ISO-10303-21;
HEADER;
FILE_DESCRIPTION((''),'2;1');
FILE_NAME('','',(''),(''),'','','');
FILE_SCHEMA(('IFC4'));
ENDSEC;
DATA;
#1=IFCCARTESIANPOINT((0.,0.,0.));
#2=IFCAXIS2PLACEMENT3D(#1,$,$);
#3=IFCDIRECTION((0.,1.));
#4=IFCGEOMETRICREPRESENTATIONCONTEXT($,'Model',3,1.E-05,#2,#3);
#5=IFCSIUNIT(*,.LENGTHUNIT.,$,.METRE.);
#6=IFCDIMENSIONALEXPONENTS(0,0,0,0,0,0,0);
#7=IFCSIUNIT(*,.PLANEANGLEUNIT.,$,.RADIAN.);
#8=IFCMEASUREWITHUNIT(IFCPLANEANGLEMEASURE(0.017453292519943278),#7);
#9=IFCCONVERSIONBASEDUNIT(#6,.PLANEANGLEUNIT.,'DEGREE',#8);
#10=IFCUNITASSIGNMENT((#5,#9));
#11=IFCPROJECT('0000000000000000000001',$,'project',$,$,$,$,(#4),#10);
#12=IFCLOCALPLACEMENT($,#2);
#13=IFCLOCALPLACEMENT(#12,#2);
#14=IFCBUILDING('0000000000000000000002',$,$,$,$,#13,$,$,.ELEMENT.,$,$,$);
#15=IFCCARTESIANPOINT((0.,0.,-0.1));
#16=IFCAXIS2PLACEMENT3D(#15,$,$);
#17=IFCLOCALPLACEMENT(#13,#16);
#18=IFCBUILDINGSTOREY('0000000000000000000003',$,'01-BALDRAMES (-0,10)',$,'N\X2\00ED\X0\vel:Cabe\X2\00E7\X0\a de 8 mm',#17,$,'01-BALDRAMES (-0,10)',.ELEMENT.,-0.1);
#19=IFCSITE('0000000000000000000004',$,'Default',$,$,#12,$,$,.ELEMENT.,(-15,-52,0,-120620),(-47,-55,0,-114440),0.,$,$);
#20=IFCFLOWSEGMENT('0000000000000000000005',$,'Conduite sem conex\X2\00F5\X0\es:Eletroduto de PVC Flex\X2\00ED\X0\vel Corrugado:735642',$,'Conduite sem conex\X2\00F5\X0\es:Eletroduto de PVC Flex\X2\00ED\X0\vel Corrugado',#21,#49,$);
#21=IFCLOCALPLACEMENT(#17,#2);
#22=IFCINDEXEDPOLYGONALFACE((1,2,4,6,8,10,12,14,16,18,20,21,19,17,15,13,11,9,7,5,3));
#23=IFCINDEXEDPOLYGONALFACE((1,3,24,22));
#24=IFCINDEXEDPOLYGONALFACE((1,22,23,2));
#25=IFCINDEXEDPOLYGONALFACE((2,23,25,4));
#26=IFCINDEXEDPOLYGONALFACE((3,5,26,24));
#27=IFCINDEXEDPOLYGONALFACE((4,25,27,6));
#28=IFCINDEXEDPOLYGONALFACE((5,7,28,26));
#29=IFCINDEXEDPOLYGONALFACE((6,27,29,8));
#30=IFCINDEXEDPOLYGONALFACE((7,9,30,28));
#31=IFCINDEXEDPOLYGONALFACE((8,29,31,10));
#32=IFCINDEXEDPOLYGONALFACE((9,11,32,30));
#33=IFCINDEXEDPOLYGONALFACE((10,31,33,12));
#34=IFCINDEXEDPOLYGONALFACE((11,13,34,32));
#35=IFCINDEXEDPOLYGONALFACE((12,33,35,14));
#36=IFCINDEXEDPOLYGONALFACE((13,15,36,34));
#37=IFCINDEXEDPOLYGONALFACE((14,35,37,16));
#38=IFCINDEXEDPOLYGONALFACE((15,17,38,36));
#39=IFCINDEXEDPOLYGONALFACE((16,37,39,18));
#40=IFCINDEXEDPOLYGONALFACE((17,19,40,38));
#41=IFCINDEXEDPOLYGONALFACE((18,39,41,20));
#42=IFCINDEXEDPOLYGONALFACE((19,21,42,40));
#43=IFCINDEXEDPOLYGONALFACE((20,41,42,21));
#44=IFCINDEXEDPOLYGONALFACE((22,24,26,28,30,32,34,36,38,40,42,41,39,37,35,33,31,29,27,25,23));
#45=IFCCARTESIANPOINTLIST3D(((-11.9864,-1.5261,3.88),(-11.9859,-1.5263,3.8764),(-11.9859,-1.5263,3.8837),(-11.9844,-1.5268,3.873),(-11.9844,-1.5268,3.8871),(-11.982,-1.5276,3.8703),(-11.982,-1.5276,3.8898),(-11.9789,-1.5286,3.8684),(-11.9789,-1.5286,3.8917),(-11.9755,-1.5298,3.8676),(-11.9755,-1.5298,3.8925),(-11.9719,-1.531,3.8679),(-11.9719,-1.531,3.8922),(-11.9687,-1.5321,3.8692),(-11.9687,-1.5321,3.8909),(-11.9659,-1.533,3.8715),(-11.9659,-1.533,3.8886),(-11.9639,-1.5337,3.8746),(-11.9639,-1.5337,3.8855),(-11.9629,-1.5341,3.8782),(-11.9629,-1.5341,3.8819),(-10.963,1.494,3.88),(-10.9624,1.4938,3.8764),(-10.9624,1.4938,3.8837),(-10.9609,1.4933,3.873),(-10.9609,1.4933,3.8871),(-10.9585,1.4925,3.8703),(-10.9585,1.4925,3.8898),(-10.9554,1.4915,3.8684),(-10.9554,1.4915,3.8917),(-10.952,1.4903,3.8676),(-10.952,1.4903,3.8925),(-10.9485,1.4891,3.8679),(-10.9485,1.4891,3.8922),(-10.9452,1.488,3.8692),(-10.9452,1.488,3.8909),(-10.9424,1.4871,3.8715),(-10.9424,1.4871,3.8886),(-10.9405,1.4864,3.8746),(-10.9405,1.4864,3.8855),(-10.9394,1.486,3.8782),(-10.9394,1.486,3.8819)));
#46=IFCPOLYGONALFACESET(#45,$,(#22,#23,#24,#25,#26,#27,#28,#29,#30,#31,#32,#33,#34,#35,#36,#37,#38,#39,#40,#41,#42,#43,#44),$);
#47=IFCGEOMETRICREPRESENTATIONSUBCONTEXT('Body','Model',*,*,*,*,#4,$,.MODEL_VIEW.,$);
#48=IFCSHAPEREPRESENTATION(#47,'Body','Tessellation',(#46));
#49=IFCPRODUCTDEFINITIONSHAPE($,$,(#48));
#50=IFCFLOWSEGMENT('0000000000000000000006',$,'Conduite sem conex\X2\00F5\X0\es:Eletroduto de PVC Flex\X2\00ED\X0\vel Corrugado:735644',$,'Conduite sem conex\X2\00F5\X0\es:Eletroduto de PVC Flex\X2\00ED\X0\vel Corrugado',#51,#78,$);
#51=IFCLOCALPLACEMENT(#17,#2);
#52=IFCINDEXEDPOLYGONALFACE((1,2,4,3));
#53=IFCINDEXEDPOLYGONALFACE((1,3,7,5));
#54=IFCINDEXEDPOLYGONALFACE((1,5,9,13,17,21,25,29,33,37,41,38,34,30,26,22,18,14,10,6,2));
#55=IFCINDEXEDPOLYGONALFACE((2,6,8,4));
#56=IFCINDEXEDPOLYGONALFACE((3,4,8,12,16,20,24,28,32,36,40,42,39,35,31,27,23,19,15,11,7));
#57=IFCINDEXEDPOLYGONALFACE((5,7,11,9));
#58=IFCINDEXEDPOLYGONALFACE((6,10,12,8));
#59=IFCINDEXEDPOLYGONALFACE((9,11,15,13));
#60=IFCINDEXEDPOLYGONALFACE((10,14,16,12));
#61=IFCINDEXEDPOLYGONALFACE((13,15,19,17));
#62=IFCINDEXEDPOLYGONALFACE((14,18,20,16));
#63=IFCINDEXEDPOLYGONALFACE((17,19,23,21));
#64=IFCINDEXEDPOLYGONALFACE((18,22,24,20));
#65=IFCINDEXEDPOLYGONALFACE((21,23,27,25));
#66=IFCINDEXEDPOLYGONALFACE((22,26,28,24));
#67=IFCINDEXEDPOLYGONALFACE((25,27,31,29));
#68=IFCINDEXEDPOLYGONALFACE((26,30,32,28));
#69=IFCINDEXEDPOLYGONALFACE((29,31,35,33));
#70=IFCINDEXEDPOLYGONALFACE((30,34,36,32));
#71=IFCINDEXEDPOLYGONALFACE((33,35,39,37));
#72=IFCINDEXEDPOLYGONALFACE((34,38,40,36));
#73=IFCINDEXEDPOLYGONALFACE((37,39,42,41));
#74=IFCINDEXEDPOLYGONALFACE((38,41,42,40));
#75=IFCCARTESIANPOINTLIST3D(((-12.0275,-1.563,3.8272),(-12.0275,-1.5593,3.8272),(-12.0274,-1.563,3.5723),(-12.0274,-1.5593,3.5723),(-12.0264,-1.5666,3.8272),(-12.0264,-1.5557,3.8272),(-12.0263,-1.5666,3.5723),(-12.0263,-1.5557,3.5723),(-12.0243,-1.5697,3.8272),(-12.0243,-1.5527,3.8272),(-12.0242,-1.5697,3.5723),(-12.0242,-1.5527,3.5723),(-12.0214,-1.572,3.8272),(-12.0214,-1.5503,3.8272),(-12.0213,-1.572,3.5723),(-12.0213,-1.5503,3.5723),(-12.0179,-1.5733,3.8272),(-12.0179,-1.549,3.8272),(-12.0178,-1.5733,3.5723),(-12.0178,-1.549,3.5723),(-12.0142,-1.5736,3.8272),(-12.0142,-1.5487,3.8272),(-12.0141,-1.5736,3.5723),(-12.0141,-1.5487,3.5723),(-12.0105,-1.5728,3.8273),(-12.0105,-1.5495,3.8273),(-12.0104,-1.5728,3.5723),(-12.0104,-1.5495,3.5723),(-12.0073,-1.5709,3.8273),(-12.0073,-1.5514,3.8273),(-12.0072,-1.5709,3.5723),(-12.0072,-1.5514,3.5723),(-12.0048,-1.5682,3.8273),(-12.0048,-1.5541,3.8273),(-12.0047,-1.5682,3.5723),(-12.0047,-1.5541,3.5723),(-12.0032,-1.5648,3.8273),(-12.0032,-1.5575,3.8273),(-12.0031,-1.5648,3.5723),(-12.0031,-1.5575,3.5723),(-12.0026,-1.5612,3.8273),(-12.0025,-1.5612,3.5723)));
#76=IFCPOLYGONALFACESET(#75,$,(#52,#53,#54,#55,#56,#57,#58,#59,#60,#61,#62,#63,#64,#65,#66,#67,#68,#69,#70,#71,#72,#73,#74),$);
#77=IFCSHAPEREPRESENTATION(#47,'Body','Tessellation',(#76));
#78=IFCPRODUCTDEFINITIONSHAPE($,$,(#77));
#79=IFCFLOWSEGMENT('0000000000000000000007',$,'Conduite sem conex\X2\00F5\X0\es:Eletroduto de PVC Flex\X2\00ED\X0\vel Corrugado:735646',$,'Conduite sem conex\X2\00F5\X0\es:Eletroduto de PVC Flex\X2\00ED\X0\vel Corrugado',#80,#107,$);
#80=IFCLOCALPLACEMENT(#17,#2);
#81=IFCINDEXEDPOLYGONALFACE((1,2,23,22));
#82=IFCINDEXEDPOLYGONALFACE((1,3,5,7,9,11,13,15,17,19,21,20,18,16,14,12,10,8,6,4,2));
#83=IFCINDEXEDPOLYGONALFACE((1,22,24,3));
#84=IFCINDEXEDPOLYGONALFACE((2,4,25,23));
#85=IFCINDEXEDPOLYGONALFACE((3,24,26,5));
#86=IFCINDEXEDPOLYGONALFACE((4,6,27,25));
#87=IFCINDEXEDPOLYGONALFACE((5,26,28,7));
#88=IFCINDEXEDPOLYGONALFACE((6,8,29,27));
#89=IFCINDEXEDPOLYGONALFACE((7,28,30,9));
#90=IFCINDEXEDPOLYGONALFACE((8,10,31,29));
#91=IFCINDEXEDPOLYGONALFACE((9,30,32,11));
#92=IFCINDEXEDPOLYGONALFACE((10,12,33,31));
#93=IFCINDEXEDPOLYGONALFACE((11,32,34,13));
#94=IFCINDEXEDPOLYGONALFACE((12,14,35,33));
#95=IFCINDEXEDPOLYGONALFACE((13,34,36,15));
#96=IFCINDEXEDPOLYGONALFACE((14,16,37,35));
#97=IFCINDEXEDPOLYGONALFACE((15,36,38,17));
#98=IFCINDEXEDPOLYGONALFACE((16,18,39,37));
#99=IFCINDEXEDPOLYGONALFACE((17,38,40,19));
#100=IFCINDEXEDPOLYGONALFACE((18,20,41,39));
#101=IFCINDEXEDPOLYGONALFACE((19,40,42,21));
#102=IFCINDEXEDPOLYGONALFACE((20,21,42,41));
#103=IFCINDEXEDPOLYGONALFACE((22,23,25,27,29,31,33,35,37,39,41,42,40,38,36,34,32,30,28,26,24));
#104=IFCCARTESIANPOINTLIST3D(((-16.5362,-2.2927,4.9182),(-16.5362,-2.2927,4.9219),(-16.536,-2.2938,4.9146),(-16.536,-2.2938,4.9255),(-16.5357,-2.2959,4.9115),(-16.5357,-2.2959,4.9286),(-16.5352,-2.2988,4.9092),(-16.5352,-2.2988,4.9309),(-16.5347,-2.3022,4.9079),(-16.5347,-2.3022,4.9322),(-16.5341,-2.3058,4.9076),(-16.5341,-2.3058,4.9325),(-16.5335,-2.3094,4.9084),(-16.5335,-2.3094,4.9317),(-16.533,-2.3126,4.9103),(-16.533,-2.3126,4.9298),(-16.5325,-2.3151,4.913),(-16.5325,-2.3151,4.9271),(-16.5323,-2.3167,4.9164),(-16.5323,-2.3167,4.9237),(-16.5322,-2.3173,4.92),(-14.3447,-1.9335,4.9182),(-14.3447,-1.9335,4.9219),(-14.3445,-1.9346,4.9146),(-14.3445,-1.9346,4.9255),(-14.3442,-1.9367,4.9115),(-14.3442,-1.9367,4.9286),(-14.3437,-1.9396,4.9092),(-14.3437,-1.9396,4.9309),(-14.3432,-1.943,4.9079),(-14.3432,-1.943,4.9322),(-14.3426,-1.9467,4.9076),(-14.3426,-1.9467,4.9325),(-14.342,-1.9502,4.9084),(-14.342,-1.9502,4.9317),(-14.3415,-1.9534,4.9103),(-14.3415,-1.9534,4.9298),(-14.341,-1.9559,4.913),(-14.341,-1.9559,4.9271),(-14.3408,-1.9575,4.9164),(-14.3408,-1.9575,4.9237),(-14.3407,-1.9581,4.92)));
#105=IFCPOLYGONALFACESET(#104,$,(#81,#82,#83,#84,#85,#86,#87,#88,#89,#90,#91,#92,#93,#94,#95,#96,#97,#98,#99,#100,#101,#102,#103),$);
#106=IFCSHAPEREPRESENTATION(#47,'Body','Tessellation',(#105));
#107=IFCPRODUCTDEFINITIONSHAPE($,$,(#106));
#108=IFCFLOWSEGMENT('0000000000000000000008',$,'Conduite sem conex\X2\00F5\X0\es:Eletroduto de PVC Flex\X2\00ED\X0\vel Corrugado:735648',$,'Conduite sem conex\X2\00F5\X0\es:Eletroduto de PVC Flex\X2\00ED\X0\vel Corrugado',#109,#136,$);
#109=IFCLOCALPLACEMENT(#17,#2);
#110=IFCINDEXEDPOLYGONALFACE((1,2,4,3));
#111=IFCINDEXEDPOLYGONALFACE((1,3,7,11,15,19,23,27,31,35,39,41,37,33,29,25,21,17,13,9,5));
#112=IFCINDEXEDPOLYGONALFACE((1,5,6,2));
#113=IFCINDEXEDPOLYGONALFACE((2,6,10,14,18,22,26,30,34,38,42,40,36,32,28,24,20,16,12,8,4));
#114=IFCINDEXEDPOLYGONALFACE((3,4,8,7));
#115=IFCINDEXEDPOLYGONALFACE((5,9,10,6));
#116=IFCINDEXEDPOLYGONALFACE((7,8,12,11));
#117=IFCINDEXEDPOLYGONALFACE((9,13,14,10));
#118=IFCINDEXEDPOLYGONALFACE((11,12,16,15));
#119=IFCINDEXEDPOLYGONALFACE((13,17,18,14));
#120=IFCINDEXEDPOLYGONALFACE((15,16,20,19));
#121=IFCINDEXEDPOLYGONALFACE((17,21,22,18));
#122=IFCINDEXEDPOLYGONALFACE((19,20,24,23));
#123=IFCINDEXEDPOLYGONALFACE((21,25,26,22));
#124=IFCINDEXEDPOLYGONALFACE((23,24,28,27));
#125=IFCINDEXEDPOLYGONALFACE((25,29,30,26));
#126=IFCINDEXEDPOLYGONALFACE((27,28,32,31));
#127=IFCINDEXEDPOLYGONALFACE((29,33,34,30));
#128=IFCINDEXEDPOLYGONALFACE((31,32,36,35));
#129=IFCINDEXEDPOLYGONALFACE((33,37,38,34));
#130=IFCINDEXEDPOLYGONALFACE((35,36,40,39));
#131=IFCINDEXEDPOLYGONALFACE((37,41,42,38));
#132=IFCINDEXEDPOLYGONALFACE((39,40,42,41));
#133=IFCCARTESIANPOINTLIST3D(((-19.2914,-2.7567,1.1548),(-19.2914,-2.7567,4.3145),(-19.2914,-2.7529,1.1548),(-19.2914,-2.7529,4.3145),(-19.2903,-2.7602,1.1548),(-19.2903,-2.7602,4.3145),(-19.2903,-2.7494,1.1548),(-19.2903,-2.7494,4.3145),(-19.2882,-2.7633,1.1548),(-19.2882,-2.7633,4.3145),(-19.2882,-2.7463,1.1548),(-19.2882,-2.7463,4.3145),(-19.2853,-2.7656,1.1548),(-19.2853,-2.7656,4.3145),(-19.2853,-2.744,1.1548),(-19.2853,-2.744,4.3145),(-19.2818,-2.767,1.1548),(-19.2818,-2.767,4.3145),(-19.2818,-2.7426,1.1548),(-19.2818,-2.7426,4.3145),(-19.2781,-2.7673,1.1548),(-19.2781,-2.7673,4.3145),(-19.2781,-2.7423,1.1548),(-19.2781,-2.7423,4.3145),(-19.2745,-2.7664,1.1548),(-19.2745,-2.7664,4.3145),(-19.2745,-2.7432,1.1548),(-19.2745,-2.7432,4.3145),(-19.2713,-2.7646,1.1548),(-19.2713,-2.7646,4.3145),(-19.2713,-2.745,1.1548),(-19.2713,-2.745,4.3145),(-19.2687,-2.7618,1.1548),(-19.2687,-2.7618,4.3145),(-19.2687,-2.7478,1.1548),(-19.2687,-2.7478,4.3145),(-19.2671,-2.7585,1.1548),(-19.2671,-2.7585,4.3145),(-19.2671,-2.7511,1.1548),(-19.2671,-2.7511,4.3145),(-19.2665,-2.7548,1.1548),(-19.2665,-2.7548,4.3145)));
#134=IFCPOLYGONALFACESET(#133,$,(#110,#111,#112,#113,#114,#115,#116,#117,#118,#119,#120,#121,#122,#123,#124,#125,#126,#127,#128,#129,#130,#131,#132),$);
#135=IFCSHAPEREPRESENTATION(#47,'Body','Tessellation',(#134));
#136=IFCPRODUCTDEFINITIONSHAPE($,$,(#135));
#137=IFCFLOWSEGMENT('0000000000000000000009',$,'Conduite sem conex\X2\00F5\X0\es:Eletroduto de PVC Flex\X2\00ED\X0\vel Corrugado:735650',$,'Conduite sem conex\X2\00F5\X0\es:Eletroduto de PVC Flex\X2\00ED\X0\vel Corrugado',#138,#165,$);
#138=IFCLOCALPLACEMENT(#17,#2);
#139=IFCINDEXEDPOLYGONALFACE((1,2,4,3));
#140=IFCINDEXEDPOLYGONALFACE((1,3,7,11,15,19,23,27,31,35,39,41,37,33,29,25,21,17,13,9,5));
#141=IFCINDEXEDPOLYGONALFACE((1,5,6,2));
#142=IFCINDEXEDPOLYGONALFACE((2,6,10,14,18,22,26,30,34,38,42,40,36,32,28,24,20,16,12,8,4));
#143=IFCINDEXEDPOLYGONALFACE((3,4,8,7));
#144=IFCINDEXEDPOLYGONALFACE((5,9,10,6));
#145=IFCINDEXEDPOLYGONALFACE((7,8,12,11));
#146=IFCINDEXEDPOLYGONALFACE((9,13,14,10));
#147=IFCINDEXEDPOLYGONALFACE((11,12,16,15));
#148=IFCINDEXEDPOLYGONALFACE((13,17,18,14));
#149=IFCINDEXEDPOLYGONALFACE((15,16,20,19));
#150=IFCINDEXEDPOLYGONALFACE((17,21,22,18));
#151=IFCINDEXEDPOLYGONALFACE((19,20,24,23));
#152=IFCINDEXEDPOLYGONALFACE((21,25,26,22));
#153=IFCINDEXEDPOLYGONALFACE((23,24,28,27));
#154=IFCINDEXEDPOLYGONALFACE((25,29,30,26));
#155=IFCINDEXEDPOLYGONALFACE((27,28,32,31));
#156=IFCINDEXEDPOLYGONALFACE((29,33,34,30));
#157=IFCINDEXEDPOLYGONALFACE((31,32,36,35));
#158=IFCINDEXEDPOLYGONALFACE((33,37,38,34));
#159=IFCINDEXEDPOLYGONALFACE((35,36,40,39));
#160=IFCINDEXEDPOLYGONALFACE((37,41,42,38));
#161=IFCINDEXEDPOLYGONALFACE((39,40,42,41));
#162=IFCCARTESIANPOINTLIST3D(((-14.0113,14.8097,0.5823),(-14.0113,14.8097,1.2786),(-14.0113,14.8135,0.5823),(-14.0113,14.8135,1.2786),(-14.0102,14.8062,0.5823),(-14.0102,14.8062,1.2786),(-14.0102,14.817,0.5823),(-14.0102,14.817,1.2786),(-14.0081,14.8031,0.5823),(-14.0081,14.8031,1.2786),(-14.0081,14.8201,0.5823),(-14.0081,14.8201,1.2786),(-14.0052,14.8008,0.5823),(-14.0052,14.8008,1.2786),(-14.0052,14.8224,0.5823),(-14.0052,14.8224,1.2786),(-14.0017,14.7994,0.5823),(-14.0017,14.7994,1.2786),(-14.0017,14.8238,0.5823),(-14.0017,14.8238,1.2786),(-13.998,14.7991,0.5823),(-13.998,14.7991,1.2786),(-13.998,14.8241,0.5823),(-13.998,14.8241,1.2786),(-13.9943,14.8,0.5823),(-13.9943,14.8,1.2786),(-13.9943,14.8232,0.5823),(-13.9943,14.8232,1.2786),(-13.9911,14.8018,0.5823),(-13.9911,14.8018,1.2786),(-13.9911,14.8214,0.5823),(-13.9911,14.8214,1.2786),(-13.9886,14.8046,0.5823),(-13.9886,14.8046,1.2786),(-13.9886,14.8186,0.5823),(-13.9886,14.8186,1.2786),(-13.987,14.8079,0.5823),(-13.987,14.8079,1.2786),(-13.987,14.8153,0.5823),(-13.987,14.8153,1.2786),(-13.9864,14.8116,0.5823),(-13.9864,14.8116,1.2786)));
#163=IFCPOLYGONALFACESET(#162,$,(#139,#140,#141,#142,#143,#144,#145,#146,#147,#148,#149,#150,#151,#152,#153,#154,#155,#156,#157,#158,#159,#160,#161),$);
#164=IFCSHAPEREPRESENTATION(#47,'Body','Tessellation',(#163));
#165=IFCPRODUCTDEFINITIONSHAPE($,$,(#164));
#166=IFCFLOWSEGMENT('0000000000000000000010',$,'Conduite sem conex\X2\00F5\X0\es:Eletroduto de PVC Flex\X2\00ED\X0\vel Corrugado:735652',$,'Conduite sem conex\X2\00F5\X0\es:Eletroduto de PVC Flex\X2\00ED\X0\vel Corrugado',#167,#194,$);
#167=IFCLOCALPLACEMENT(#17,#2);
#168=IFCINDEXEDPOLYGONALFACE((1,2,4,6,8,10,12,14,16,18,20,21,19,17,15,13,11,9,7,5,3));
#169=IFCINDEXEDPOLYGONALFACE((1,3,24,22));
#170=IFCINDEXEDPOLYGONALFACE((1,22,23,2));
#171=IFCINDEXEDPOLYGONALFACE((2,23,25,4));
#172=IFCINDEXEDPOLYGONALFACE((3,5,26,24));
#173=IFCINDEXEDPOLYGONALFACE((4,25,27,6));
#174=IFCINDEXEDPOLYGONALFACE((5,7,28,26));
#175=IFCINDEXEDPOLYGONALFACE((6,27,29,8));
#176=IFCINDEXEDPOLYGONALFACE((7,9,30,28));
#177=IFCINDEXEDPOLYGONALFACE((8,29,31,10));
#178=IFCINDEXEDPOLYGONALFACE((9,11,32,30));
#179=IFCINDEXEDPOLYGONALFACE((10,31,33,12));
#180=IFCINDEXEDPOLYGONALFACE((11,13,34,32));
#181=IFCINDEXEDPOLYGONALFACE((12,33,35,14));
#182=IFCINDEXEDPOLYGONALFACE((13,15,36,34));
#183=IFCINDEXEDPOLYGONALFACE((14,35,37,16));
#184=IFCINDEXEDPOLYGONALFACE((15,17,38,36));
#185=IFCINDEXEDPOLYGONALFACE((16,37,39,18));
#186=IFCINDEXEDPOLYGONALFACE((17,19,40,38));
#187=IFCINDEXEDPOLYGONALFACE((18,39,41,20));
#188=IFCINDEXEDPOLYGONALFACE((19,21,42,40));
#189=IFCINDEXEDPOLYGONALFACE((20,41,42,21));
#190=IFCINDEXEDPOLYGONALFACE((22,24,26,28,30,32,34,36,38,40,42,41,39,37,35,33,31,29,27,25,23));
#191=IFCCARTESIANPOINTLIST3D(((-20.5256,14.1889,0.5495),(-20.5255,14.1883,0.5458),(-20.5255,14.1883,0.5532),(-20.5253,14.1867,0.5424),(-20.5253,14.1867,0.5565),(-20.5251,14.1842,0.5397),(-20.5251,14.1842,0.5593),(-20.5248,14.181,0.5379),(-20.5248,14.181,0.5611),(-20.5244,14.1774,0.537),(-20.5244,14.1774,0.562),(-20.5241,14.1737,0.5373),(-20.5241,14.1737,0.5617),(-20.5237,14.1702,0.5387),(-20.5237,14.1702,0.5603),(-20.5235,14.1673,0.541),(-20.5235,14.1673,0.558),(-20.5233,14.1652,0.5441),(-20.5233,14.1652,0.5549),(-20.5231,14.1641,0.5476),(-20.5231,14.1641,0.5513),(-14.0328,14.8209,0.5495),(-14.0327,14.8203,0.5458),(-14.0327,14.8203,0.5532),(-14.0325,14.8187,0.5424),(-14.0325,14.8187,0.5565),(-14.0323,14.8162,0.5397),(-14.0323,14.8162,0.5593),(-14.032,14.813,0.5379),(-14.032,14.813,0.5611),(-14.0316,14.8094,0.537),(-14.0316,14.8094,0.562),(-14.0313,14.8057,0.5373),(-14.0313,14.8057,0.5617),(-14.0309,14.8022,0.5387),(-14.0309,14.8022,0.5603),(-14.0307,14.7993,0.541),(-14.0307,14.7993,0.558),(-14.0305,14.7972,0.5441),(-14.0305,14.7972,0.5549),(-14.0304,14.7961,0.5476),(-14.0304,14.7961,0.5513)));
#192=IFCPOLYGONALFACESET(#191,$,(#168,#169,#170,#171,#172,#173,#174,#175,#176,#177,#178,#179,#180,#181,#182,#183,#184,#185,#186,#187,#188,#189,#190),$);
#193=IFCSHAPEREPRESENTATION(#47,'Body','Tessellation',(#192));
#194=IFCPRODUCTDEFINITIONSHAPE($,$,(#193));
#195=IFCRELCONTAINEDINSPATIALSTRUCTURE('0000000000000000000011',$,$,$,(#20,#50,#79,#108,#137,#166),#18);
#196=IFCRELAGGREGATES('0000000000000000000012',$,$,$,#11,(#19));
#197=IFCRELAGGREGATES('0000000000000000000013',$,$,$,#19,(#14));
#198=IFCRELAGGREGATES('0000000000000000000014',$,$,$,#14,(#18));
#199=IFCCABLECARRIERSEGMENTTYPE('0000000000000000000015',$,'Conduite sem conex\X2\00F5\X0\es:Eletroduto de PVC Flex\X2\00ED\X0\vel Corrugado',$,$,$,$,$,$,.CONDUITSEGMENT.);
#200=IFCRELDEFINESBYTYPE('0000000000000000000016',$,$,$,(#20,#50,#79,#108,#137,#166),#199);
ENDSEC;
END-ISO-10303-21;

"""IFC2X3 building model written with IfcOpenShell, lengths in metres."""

from ifc_helpers import new_model, entity, si_unit, converted_unit, direction, frame, frame_2d, origin, origin_2d_with_axis, place, context, subcontext, project, spatial, circle, extrude, type_object, element, save


model = new_model("IFC2X3")

# Units and contexts
model_context = context("Model", 3, precision=1e-05, world=origin(), true_north=direction((0.0, 1.0)))
body_context = subcontext(model_context, "Body", "Model", "MODEL_VIEW")
ifc_project = project(units=[si_unit("LENGTHUNIT", "METRE"), converted_unit("PLANEANGLEUNIT", "DEGREE", entity("IfcPlaneAngleMeasure", 0.017453292519943278), si_unit("PLANEANGLEUNIT", "RADIAN"), dimensions=[0, 0, 0, 0, 0, 0, 0])], contexts=[model_context])

# Site, building, storey
site_placement = place(None, origin())
site = spatial("IfcSite", under=ifc_project, at=site_placement, Name="Default", CompositionType="ELEMENT", RefLatitude=(-15, -52, 0, -120620), RefLongitude=(-47, -55, 0, -114440), RefElevation=0.0)
building_placement = place(site_placement, origin())
building = spatial("IfcBuilding", under=site, at=building_placement, CompositionType="ELEMENT")
storey_placement = place(building_placement, frame((0.0, 0.0, -0.1)))
storey = spatial("IfcBuildingStorey", under=building, at=storey_placement, Name="01-BALDRAMES (-0,10)", ObjectType="Nível:Cabeça de 8 mm", LongName="01-BALDRAMES (-0,10)", CompositionType="ELEMENT", Elevation=-0.1)

# Flow segments
cable_carrier_segment_type = type_object("IfcCableCarrierSegmentType", Name="Conduite sem conexões:Eletroduto de PVC Flexível Corrugado", PredefinedType="CONDUITSEGMENT")
flow_segment_1_placement = place(storey_placement, origin())
element("IfcFlowSegment", 1, at=flow_segment_1_placement, inside=storey, type_object=cable_carrier_segment_type, Name="Conduite sem conexões:Eletroduto de PVC Flexível Corrugado:735642", ObjectType="Conduite sem conexões:Eletroduto de PVC Flexível Corrugado", context=body_context, shape_type="SweptSolid", body=[
    extrude(circle(Radius=0.0125, at=frame_2d((0.0, 0.0), x_axis=(1.0, 0.0))), frame((-11.9746, -1.5301, 3.88), z_axis=(0.320953, 0.947095, 0.0), x_axis=(-0.947095, 0.320953, 0.0)), (0.0, 0.0, 1.0), 3.1888),
])
flow_segment_2_placement = place(storey_placement, origin())
element("IfcFlowSegment", 2, at=flow_segment_2_placement, inside=storey, type_object=cable_carrier_segment_type, Name="Conduite sem conexões:Eletroduto de PVC Flexível Corrugado:735644", ObjectType="Conduite sem conexões:Eletroduto de PVC Flexível Corrugado", context=body_context, shape_type="SweptSolid", body=[
    extrude(circle(Radius=0.0125, at=origin_2d_with_axis()), frame((-12.015, -1.5612, 3.5723), z_axis=(-0.00036, 0.0, 1.0), x_axis=(1.0, 0.0, 0.00036)), (0.0, 0.0, 1.0), 0.2549),
])
flow_segment_3_placement = place(storey_placement, origin())
element("IfcFlowSegment", 3, at=flow_segment_3_placement, inside=storey, type_object=cable_carrier_segment_type, Name="Conduite sem conexões:Eletroduto de PVC Flexível Corrugado:735646", ObjectType="Conduite sem conexões:Eletroduto de PVC Flexível Corrugado", context=body_context, shape_type="SweptSolid", body=[
    extrude(circle(Radius=0.0125, at=origin_2d_with_axis()), frame((-16.5342, -2.3049, 4.92), z_axis=(0.986833, 0.161741, 0.0), x_axis=(0.161741, -0.986833, 0.0)), (0.0, 0.0, 1.0), 2.2207),
])
flow_segment_4_placement = place(storey_placement, origin())
element("IfcFlowSegment", 4, at=flow_segment_4_placement, inside=storey, type_object=cable_carrier_segment_type, Name="Conduite sem conexões:Eletroduto de PVC Flexível Corrugado:735648", ObjectType="Conduite sem conexões:Eletroduto de PVC Flexível Corrugado", context=body_context, shape_type="SweptSolid", body=[
    extrude(circle(Radius=0.0125, at=frame_2d((0.0, 0.0), x_axis=(1.0, 0.0))), frame((-19.279, -2.7548, 1.1548)), (0.0, 0.0, 1.0), 3.1597),
])
flow_segment_5_placement = place(storey_placement, origin())
element("IfcFlowSegment", 5, at=flow_segment_5_placement, inside=storey, type_object=cable_carrier_segment_type, Name="Conduite sem conexões:Eletroduto de PVC Flexível Corrugado:735650", ObjectType="Conduite sem conexões:Eletroduto de PVC Flexível Corrugado", context=body_context, shape_type="SweptSolid", body=[
    extrude(circle(Radius=0.0125, at=frame_2d((0.0, 0.0), x_axis=(1.0, 0.0))), frame((-13.9989, 14.8116, 0.5823)), (0.0, 0.0, 1.0), 0.6963),
])
flow_segment_6_placement = place(storey_placement, origin())
element("IfcFlowSegment", 6, at=flow_segment_6_placement, inside=storey, type_object=cable_carrier_segment_type, Name="Conduite sem conexões:Eletroduto de PVC Flexível Corrugado:735652", ObjectType="Conduite sem conexões:Eletroduto de PVC Flexível Corrugado", context=body_context, shape_type="SweptSolid", body=[
    extrude(circle(Radius=0.0125, at=origin_2d_with_axis()), frame((-20.5243, 14.1764, 0.5495), z_axis=(0.995296, 0.09688, 0.0), x_axis=(-0.09688, 0.995296, 0.0)), (0.0, 0.0, 1.0), 6.5235),
])

save(model, "model.ifc")
